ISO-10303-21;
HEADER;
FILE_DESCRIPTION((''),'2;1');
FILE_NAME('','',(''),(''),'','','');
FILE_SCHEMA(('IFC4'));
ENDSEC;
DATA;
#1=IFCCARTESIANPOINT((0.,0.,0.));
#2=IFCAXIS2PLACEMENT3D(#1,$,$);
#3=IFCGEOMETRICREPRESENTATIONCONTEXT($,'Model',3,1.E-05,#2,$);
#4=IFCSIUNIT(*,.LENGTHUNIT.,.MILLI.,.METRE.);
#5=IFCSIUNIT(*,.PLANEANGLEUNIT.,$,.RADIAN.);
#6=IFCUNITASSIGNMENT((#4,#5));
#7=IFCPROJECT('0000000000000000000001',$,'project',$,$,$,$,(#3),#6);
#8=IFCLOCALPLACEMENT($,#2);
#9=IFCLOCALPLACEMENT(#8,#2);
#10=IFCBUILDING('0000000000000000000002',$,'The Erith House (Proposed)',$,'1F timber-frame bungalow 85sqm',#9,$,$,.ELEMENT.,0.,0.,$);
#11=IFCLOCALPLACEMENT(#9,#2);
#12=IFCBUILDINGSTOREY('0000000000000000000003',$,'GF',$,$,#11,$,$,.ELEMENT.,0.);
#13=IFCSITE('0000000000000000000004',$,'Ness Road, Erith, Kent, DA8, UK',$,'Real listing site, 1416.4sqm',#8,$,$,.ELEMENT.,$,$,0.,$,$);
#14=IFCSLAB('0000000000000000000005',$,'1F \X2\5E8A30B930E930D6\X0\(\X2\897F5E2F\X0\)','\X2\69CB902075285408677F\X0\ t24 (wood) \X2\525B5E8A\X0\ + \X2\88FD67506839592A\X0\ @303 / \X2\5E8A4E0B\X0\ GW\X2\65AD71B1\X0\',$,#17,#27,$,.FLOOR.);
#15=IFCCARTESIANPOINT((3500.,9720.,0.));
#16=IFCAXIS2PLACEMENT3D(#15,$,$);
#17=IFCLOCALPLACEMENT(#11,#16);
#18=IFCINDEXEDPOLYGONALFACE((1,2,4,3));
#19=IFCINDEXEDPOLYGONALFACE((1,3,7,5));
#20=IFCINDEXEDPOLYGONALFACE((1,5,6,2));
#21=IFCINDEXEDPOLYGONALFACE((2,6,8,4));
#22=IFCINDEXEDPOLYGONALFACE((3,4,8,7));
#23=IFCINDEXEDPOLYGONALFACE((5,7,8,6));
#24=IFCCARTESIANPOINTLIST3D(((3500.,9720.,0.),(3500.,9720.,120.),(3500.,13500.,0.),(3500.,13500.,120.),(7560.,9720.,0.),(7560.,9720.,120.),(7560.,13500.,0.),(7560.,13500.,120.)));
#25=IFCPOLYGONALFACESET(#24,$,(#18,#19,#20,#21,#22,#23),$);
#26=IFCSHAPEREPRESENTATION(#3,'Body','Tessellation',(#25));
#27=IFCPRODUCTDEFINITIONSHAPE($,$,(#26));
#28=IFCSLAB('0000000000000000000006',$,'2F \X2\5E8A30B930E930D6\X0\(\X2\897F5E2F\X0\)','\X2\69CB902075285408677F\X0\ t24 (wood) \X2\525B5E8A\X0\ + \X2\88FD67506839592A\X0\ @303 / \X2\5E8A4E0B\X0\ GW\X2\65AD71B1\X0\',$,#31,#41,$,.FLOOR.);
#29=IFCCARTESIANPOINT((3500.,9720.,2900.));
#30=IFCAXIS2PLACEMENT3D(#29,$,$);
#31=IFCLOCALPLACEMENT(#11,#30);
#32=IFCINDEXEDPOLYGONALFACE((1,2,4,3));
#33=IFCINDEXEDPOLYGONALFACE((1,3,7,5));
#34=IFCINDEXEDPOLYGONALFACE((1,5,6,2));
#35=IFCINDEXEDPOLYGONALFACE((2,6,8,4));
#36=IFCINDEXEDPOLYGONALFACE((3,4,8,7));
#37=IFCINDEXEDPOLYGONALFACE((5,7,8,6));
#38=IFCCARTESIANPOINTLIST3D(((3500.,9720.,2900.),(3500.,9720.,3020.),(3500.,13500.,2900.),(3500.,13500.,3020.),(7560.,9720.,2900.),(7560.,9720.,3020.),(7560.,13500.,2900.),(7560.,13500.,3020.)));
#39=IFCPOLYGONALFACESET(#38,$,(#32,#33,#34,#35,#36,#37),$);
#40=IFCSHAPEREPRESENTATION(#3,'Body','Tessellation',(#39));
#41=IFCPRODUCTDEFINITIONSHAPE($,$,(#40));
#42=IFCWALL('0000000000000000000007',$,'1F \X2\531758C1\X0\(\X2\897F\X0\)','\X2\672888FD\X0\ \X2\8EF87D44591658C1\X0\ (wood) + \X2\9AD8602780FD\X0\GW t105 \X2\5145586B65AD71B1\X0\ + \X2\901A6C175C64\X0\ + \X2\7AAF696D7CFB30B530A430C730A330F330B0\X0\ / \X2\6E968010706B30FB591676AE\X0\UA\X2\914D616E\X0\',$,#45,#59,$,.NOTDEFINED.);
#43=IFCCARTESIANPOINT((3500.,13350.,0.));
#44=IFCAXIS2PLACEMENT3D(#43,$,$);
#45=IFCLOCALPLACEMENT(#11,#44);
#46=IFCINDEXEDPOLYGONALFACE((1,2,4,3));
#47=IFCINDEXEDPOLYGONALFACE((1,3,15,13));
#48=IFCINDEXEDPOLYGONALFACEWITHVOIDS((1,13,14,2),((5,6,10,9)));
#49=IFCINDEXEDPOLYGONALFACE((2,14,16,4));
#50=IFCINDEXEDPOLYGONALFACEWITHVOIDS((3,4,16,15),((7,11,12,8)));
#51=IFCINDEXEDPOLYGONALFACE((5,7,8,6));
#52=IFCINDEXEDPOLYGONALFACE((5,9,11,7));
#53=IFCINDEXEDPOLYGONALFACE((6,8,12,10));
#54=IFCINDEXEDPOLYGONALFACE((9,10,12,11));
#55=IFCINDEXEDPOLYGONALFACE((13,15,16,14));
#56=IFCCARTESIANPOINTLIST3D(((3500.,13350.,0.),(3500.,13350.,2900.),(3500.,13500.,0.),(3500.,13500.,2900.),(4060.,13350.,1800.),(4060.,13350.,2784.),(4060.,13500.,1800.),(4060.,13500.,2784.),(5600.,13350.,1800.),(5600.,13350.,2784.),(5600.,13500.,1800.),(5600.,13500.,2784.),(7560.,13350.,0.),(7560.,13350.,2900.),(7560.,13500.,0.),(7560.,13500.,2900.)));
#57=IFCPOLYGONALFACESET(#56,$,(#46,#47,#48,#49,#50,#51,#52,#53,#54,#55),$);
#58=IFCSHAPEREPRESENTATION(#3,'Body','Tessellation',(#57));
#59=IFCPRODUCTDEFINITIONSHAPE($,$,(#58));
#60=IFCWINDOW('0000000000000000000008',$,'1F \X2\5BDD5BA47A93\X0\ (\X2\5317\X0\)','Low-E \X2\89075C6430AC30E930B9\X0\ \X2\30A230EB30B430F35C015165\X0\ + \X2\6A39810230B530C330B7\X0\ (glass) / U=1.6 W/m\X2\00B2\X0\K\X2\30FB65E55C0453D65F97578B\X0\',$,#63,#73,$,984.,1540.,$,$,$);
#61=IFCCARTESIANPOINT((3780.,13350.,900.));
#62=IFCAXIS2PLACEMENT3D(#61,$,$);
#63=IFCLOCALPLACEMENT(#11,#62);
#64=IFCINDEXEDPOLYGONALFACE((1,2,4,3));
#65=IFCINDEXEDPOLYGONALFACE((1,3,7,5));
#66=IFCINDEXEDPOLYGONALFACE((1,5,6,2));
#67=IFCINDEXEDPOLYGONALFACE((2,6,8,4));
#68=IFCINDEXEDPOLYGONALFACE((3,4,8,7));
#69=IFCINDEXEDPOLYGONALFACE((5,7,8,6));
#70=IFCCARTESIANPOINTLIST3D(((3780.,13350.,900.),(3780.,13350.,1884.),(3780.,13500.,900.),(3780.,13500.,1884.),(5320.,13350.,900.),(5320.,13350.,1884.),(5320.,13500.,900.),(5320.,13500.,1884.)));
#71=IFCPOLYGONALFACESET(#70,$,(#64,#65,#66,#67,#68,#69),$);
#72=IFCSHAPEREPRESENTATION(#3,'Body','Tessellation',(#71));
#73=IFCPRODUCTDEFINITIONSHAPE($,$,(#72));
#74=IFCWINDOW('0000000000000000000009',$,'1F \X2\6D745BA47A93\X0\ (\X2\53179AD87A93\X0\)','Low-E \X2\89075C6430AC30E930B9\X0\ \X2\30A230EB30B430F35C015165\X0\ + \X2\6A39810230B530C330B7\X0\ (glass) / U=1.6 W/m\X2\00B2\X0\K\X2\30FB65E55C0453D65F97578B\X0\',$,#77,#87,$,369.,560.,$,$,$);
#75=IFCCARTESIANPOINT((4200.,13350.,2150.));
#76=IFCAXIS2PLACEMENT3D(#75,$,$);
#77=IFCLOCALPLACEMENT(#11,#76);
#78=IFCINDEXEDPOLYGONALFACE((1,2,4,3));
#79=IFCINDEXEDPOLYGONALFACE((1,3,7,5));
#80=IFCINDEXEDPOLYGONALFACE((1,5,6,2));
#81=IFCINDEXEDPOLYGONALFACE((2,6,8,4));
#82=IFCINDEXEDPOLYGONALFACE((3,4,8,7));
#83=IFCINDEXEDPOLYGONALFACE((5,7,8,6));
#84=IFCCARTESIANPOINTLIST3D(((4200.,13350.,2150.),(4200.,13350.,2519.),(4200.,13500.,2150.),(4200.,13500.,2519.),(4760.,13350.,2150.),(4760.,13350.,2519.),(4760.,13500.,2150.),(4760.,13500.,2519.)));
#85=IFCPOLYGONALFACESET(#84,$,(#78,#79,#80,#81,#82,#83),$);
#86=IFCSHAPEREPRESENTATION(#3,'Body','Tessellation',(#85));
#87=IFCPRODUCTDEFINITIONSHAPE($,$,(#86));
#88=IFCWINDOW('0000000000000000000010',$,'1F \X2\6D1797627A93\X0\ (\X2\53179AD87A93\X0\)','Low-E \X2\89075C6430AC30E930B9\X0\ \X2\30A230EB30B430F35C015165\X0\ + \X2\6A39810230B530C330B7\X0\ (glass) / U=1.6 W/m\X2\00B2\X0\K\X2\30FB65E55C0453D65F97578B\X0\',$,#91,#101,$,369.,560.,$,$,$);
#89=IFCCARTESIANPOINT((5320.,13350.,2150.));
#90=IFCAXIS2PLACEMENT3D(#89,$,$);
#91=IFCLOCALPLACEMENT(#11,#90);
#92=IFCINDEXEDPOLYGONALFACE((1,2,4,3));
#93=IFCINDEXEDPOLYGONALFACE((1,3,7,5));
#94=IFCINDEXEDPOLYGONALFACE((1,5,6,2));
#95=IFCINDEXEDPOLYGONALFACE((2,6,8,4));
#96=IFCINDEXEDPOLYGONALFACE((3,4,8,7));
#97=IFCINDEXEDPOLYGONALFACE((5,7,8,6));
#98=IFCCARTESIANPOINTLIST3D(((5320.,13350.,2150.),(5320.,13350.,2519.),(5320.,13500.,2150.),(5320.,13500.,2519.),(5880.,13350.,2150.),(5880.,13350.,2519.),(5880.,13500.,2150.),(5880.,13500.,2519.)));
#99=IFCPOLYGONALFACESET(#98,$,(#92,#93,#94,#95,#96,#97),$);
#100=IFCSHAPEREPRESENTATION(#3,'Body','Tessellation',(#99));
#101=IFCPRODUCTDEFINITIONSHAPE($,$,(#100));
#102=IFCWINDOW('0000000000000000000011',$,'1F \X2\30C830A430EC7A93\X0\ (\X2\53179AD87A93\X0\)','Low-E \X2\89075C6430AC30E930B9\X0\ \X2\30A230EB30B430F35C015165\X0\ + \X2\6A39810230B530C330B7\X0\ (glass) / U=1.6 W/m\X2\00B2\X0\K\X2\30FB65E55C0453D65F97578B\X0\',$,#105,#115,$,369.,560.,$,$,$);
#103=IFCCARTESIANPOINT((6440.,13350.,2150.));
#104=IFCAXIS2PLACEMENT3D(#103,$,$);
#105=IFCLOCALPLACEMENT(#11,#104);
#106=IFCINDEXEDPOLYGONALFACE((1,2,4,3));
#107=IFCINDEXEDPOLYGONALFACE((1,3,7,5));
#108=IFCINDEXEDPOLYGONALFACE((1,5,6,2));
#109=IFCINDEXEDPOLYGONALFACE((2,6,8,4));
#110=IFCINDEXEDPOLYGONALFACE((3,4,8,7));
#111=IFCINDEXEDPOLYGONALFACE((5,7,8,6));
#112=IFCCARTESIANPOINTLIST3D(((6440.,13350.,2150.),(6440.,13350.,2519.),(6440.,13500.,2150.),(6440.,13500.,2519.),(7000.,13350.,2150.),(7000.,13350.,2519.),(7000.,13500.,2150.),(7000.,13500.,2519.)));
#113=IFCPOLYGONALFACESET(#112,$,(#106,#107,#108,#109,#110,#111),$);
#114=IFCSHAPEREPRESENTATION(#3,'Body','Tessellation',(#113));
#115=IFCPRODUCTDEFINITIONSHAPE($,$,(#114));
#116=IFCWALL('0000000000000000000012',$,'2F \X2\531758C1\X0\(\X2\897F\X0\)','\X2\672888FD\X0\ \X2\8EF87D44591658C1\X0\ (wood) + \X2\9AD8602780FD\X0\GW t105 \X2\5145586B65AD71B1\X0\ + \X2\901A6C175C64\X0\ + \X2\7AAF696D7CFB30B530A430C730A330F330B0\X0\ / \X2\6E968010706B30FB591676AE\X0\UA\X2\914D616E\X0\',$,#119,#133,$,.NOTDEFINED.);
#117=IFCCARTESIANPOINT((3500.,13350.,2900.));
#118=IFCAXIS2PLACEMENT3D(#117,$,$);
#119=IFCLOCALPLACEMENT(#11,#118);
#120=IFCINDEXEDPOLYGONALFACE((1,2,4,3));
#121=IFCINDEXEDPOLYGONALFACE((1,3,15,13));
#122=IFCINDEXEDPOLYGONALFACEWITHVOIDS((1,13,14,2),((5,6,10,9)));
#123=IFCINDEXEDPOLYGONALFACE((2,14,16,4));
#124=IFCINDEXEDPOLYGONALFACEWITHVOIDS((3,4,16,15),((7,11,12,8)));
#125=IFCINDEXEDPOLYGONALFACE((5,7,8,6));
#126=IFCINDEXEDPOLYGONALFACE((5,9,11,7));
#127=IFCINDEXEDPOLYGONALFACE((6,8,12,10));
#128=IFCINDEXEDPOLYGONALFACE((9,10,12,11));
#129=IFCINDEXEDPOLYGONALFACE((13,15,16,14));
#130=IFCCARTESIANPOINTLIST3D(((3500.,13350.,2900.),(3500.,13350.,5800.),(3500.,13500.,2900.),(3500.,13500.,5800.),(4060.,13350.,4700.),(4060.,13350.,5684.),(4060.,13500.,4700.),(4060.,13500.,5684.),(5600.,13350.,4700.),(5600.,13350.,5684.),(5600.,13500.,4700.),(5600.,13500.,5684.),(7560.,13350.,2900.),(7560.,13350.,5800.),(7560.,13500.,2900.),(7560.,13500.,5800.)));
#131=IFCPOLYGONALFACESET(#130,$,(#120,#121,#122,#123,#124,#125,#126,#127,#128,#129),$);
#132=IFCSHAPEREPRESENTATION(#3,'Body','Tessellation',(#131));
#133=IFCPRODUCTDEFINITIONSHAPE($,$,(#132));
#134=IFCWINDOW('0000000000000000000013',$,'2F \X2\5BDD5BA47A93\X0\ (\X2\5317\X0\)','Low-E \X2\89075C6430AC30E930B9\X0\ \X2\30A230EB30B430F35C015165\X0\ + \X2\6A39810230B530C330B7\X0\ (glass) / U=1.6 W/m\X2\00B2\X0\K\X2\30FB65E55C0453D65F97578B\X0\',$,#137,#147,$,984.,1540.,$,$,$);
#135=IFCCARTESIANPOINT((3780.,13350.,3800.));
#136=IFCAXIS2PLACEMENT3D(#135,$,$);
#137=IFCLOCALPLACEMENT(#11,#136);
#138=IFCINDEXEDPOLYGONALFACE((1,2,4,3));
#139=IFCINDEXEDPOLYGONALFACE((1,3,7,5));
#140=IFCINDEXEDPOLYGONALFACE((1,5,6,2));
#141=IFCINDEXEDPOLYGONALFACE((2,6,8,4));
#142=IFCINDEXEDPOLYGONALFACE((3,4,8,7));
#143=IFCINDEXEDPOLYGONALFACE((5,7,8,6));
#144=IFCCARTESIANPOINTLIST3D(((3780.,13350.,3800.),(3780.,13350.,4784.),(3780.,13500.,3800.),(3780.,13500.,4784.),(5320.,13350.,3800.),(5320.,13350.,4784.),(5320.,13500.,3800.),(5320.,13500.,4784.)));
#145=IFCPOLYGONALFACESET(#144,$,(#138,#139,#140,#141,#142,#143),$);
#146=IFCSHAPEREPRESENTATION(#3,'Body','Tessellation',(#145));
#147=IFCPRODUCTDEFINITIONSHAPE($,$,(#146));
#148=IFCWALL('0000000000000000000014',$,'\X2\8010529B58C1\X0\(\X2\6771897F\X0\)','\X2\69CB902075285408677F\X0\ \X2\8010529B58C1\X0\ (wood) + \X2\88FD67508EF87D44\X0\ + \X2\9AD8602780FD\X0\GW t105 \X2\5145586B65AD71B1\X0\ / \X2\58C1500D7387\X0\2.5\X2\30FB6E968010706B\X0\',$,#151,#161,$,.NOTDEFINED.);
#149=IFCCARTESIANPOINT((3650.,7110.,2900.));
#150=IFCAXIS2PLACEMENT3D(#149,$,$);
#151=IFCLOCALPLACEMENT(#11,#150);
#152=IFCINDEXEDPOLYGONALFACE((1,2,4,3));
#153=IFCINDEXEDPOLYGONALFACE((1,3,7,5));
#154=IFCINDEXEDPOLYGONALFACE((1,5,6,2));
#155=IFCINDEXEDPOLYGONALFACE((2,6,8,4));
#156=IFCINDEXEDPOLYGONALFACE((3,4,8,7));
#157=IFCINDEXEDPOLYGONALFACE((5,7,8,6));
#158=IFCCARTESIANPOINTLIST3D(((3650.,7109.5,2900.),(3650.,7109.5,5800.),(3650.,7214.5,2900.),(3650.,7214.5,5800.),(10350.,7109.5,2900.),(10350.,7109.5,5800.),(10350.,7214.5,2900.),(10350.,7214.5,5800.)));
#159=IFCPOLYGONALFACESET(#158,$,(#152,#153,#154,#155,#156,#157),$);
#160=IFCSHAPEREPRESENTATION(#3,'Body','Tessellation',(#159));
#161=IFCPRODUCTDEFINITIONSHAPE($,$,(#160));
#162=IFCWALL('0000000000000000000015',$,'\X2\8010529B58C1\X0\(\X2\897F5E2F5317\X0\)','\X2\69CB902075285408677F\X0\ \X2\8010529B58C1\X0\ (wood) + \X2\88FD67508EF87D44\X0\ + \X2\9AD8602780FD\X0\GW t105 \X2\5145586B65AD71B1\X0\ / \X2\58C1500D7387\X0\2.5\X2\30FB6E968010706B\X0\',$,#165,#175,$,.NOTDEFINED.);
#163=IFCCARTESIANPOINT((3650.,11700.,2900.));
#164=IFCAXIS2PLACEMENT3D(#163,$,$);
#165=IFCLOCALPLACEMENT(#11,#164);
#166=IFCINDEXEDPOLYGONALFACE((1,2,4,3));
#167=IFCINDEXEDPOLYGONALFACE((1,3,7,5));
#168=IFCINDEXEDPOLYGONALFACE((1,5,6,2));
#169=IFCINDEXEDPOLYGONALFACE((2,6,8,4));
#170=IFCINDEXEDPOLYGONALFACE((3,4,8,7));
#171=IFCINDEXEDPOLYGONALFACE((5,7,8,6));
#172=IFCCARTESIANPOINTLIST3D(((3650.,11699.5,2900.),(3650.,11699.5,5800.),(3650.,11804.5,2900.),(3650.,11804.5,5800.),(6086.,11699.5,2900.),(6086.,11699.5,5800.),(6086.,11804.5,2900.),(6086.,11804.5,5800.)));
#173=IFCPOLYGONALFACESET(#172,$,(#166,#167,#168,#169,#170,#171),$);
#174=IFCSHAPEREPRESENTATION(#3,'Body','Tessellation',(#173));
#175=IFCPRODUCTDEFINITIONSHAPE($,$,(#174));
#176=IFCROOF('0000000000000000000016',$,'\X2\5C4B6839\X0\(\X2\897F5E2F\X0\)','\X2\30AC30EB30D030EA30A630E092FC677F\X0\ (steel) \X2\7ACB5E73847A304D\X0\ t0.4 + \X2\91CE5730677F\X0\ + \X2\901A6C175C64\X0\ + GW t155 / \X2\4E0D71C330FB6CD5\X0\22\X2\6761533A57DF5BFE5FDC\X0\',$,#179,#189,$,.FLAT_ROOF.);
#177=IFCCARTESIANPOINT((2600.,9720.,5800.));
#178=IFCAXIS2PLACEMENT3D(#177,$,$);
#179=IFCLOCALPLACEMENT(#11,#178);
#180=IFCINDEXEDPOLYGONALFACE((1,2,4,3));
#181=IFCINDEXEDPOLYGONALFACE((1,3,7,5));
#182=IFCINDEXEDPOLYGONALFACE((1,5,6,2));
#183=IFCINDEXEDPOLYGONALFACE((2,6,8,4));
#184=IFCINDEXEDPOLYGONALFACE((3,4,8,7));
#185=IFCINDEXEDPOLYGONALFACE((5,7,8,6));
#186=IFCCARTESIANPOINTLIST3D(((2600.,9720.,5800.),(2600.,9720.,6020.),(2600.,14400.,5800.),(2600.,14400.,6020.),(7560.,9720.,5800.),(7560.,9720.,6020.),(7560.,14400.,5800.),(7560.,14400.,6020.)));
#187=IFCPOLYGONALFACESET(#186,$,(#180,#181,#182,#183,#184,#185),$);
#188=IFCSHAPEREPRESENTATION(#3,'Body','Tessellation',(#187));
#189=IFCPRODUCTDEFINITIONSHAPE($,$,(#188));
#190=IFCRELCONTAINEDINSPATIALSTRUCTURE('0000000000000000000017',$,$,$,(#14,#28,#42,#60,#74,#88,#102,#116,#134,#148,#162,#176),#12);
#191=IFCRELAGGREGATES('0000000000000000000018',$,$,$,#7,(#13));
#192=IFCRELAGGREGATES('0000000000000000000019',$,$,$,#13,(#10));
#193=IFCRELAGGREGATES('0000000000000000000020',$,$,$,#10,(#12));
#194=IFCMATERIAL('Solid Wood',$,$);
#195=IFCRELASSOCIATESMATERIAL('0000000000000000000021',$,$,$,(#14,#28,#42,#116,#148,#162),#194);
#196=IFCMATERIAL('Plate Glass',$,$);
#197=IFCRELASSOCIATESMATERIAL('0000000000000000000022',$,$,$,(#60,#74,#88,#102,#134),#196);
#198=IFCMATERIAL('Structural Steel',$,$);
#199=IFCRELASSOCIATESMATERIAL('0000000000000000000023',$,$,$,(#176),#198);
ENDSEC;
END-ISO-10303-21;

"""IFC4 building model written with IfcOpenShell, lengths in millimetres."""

from ifc_helpers import new_model, si_unit, frame, frame_2d, origin, place, context, project, spatial, rectangle, extrude, material, element, fill, save


model = new_model("IFC4")

# Units and contexts
model_context = context("Model", 3, precision=1e-05, world=origin())
ifc_project = project(units=[si_unit("LENGTHUNIT", "METRE", prefix="MILLI"), si_unit("PLANEANGLEUNIT", "RADIAN")], contexts=[model_context])

# Site, building, storey
site_placement = place(None, origin())
site = spatial("IfcSite", under=ifc_project, at=site_placement, Name="Ness Road, Erith, Kent, DA8, UK", ObjectType="Real listing site, 1416.4sqm", CompositionType="ELEMENT", RefElevation=0.0)
building_placement = place(site_placement, origin())
building = spatial("IfcBuilding", under=site, at=building_placement, Name="The Erith House (Proposed)", ObjectType="1F timber-frame bungalow 85sqm", CompositionType="ELEMENT", ElevationOfRefHeight=0.0, ElevationOfTerrain=0.0)
storey_placement = place(building_placement, origin())
storey = spatial("IfcBuildingStorey", under=building, at=storey_placement, Name="GF", CompositionType="ELEMENT", Elevation=0.0)

# Slabs
ifc_material_1 = material(Name="Solid Wood")
slab_1_placement = place(storey_placement, frame((3500.0, 9720.0, 0.0)))
element("IfcSlab", 1, at=slab_1_placement, inside=storey, material=ifc_material_1, Name="1F 床スラブ(西帯)", Description="構造用合板 t24 (wood) 剛床 + 製材根太 @303 / 床下 GW断熱", PredefinedType="FLOOR", context=model_context, shape_type="SweptSolid", body=[
    extrude(rectangle(XDim=4060.0, YDim=3780.0, at=frame_2d((2030.0, 1890.0))), frame((3500.0, 9720.0, 0.0)), (0.0, 0.0, 1.0), 120.0),
])
slab_2_placement = place(storey_placement, frame((3500.0, 9720.0, 2900.0)))
element("IfcSlab", 2, at=slab_2_placement, inside=storey, material=ifc_material_1, Name="2F 床スラブ(西帯)", Description="構造用合板 t24 (wood) 剛床 + 製材根太 @303 / 床下 GW断熱", PredefinedType="FLOOR", context=model_context, shape_type="SweptSolid", body=[
    extrude(rectangle(XDim=4060.0, YDim=3780.0, at=frame_2d((2030.0, 1890.0))), frame((3500.0, 9720.0, 2900.0)), (0.0, 0.0, 1.0), 120.0),
])

# Wall, openings, windows
wall_1_placement = place(storey_placement, frame((3500.0, 13350.0, 0.0)))
wall_1 = element("IfcWall", 3, at=wall_1_placement, inside=storey, material=ifc_material_1, Name="1F 北壁(西)", Description="木製 軸組外壁 (wood) + 高性能GW t105 充填断熱 + 通気層 + 窯業系サイディング / 準耐火・外皮UA配慮", PredefinedType="NOTDEFINED", context=model_context, shape_type="SweptSolid", body=[
    extrude(rectangle(XDim=4060.0, YDim=150.0, at=frame_2d((2030.0, 75.0))), frame((3500.0, 13350.0, 0.0)), (0.0, 0.0, 1.0), 2900.0),
])
opening_1_placement = place(storey_placement, frame((3780.0, 13350.0, 900.0)))
opening_1 = element("IfcOpeningElement", 4, at=opening_1_placement, cuts=wall_1, PredefinedType="NOTDEFINED", context=model_context, shape_type="SweptSolid", body=[
    extrude(rectangle(XDim=1540.0, YDim=150.0, at=frame_2d((770.0, 75.0))), frame((3780.0, 13350.0, 900.0)), (0.0, 0.0, 1.0), 984.0),
])
opening_2_placement = place(storey_placement, frame((4200.0, 13350.0, 2150.0)))
opening_2 = element("IfcOpeningElement", 5, at=opening_2_placement, cuts=wall_1, PredefinedType="NOTDEFINED", context=model_context, shape_type="SweptSolid", body=[
    extrude(rectangle(XDim=560.0, YDim=150.0, at=frame_2d((280.0, 75.0))), frame((4200.0, 13350.0, 2150.0)), (0.0, 0.0, 1.0), 369.0),
])
opening_3_placement = place(storey_placement, frame((5320.0, 13350.0, 2150.0)))
opening_3 = element("IfcOpeningElement", 6, at=opening_3_placement, cuts=wall_1, PredefinedType="NOTDEFINED", context=model_context, shape_type="SweptSolid", body=[
    extrude(rectangle(XDim=560.0, YDim=150.0, at=frame_2d((280.0, 75.0))), frame((5320.0, 13350.0, 2150.0)), (0.0, 0.0, 1.0), 369.0),
])
opening_4_placement = place(storey_placement, frame((6440.0, 13350.0, 2150.0)))
opening_4 = element("IfcOpeningElement", 7, at=opening_4_placement, cuts=wall_1, PredefinedType="NOTDEFINED", context=model_context, shape_type="SweptSolid", body=[
    extrude(rectangle(XDim=560.0, YDim=150.0, at=frame_2d((280.0, 75.0))), frame((6440.0, 13350.0, 2150.0)), (0.0, 0.0, 1.0), 369.0),
])
ifc_material_2 = material(Name="Plate Glass")
window_1_placement = place(storey_placement, frame((3780.0, 13350.0, 900.0)))
window_1 = element("IfcWindow", 8, at=window_1_placement, inside=storey, material=ifc_material_2, Name="1F 寝室窓 (北)", Description="Low-E 複層ガラス アルゴン封入 + 樹脂サッシ (glass) / U=1.6 W/m²K・日射取得型", OverallHeight=984.0, OverallWidth=1540.0, context=model_context, shape_type="SweptSolid", body=[
    extrude(rectangle(XDim=1540.0, YDim=150.0, at=frame_2d((770.0, 75.0))), frame((3780.0, 13350.0, 900.0)), (0.0, 0.0, 1.0), 984.0),
])
fill(opening_1, window_1)
window_2_placement = place(storey_placement, frame((4200.0, 13350.0, 2150.0)))
window_2 = element("IfcWindow", 9, at=window_2_placement, inside=storey, material=ifc_material_2, Name="1F 浴室窓 (北高窓)", Description="Low-E 複層ガラス アルゴン封入 + 樹脂サッシ (glass) / U=1.6 W/m²K・日射取得型", OverallHeight=369.0, OverallWidth=560.0, context=model_context, shape_type="SweptSolid", body=[
    extrude(rectangle(XDim=560.0, YDim=150.0, at=frame_2d((280.0, 75.0))), frame((4200.0, 13350.0, 2150.0)), (0.0, 0.0, 1.0), 369.0),
])
fill(opening_2, window_2)
window_3_placement = place(storey_placement, frame((5320.0, 13350.0, 2150.0)))
window_3 = element("IfcWindow", 10, at=window_3_placement, inside=storey, material=ifc_material_2, Name="1F 洗面窓 (北高窓)", Description="Low-E 複層ガラス アルゴン封入 + 樹脂サッシ (glass) / U=1.6 W/m²K・日射取得型", OverallHeight=369.0, OverallWidth=560.0, context=model_context, shape_type="SweptSolid", body=[
    extrude(rectangle(XDim=560.0, YDim=150.0, at=frame_2d((280.0, 75.0))), frame((5320.0, 13350.0, 2150.0)), (0.0, 0.0, 1.0), 369.0),
])
fill(opening_3, window_3)
window_4_placement = place(storey_placement, frame((6440.0, 13350.0, 2150.0)))
window_4 = element("IfcWindow", 11, at=window_4_placement, inside=storey, material=ifc_material_2, Name="1F トイレ窓 (北高窓)", Description="Low-E 複層ガラス アルゴン封入 + 樹脂サッシ (glass) / U=1.6 W/m²K・日射取得型", OverallHeight=369.0, OverallWidth=560.0, context=model_context, shape_type="SweptSolid", body=[
    extrude(rectangle(XDim=560.0, YDim=150.0, at=frame_2d((280.0, 75.0))), frame((6440.0, 13350.0, 2150.0)), (0.0, 0.0, 1.0), 369.0),
])
fill(opening_4, window_4)

# Wall, opening, window
wall_2_placement = place(storey_placement, frame((3500.0, 13350.0, 2900.0)))
wall_2 = element("IfcWall", 12, at=wall_2_placement, inside=storey, material=ifc_material_1, Name="2F 北壁(西)", Description="木製 軸組外壁 (wood) + 高性能GW t105 充填断熱 + 通気層 + 窯業系サイディング / 準耐火・外皮UA配慮", PredefinedType="NOTDEFINED", context=model_context, shape_type="SweptSolid", body=[
    extrude(rectangle(XDim=4060.0, YDim=150.0, at=frame_2d((2030.0, 75.0))), frame((3500.0, 13350.0, 2900.0)), (0.0, 0.0, 1.0), 2900.0),
])
opening_5_placement = place(storey_placement, frame((3780.0, 13350.0, 3800.0)))
opening_5 = element("IfcOpeningElement", 13, at=opening_5_placement, cuts=wall_2, PredefinedType="NOTDEFINED", context=model_context, shape_type="SweptSolid", body=[
    extrude(rectangle(XDim=1540.0, YDim=150.0, at=frame_2d((770.0, 75.0))), frame((3780.0, 13350.0, 3800.0)), (0.0, 0.0, 1.0), 984.0),
])
window_5_placement = place(storey_placement, frame((3780.0, 13350.0, 3800.0)))
window_5 = element("IfcWindow", 14, at=window_5_placement, inside=storey, material=ifc_material_2, Name="2F 寝室窓 (北)", Description="Low-E 複層ガラス アルゴン封入 + 樹脂サッシ (glass) / U=1.6 W/m²K・日射取得型", OverallHeight=984.0, OverallWidth=1540.0, context=model_context, shape_type="SweptSolid", body=[
    extrude(rectangle(XDim=1540.0, YDim=150.0, at=frame_2d((770.0, 75.0))), frame((3780.0, 13350.0, 3800.0)), (0.0, 0.0, 1.0), 984.0),
])
fill(opening_5, window_5)

# Walls
wall_3_placement = place(storey_placement, frame((3650.0, 7110.0, 2900.0)))
element("IfcWall", 15, at=wall_3_placement, inside=storey, material=ifc_material_1, Name="耐力壁(東西)", Description="構造用合板 耐力壁 (wood) + 製材軸組 + 高性能GW t105 充填断熱 / 壁倍率2.5・準耐火", PredefinedType="NOTDEFINED", context=model_context, shape_type="SweptSolid", body=[
    extrude(rectangle(XDim=6700.0, YDim=105.0, at=frame_2d((3350.0, 52.0))), frame((3650.0, 7110.0, 2900.0)), (0.0, 0.0, 1.0), 2900.0),
])
wall_4_placement = place(storey_placement, frame((3650.0, 11700.0, 2900.0)))
element("IfcWall", 16, at=wall_4_placement, inside=storey, material=ifc_material_1, Name="耐力壁(西帯北)", Description="構造用合板 耐力壁 (wood) + 製材軸組 + 高性能GW t105 充填断熱 / 壁倍率2.5・準耐火", PredefinedType="NOTDEFINED", context=model_context, shape_type="SweptSolid", body=[
    extrude(rectangle(XDim=2436.0, YDim=105.0, at=frame_2d((1218.0, 52.0))), frame((3650.0, 11700.0, 2900.0)), (0.0, 0.0, 1.0), 2900.0),
])

# Roof
ifc_material_3 = material(Name="Structural Steel")
for number, where, name in (
    (17, (2600.0, 9720.0, 5800.0), "屋根(西帯)"),
):
    element("IfcRoof", number, at=place(storey_placement, frame(where)), inside=storey, material=ifc_material_3, Name=name, Description="ガルバリウム鋼板 (steel) 立平葺き t0.4 + 野地板 + 通気層 + GW t155 / 不燃・法22条区域対応", PredefinedType="FLAT_ROOF", context=model_context, shape_type="SweptSolid", body=[
        extrude(rectangle(XDim=4960.0, YDim=4680.0, at=frame_2d((2480.0, 2340.0))), frame((2600.0, 9720.0, 5800.0)), (0.0, 0.0, 1.0), 220.0),
    ])

save(model, "model.ifc")
